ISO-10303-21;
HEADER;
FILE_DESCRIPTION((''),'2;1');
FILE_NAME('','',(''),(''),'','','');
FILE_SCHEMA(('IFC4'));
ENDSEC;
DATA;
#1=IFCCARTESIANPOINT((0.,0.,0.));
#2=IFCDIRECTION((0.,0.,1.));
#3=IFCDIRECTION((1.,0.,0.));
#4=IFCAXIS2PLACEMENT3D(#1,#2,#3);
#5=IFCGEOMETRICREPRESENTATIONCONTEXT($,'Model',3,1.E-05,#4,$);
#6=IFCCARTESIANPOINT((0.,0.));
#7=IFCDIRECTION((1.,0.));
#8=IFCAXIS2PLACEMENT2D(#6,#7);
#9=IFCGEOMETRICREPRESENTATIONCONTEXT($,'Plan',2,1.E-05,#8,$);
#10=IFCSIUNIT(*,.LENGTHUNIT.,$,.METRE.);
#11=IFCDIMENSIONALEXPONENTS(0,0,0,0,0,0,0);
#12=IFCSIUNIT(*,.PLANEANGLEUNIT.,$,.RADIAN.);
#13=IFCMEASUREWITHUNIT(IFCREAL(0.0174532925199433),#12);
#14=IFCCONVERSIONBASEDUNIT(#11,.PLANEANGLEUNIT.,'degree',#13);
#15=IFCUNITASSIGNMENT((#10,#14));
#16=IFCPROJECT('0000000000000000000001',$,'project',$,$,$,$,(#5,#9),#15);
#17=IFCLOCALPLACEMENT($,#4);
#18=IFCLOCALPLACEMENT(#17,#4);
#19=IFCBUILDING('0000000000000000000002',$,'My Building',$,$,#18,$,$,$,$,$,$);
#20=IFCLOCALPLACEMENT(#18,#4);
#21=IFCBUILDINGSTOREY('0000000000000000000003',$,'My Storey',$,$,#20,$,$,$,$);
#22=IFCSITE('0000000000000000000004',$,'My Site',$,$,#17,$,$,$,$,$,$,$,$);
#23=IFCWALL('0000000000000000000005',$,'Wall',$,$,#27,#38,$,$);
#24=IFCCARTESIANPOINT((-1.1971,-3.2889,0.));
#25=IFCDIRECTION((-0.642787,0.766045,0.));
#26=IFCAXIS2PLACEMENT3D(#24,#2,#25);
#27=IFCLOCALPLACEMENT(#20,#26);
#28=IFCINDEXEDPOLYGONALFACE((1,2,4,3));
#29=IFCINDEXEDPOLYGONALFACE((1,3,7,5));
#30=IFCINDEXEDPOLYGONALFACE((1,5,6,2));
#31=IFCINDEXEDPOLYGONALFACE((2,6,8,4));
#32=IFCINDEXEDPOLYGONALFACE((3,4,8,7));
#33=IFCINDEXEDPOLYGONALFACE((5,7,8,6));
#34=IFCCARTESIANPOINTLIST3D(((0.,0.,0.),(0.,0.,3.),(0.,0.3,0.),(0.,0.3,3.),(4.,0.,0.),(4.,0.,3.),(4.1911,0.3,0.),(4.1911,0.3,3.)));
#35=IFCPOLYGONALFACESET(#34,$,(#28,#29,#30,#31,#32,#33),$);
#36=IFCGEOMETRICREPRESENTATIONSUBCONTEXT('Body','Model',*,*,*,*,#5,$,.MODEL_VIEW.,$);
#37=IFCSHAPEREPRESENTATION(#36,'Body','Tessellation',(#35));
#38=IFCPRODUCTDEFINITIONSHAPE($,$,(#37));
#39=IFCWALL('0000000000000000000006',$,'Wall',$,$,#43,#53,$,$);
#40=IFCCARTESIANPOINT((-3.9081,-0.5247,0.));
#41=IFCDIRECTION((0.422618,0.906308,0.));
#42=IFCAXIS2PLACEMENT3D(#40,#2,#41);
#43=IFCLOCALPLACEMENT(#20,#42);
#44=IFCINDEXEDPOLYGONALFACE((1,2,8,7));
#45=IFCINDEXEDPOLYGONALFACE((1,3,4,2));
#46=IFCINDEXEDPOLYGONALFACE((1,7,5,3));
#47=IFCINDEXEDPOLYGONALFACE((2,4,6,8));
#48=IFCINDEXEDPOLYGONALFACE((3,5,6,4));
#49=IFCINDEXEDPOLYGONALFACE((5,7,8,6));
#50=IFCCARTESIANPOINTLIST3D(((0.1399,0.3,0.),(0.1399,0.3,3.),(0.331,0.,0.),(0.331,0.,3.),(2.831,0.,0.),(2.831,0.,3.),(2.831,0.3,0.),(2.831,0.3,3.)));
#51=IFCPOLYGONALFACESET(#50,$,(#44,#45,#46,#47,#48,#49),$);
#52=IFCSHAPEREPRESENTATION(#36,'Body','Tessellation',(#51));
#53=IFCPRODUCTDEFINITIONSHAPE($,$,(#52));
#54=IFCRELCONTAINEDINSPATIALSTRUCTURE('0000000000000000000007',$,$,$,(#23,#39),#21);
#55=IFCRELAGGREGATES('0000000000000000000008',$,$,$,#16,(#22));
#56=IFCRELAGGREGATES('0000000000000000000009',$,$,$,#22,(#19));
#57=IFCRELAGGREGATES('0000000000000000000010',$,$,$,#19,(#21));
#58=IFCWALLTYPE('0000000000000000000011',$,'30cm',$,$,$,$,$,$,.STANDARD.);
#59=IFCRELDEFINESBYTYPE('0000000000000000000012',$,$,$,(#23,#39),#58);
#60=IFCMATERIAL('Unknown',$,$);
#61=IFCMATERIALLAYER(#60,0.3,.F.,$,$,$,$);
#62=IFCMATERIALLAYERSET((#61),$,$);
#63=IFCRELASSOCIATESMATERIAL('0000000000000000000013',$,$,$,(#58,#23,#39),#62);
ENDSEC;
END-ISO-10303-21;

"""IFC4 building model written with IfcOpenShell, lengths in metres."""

from ifc_helpers import new_model, entity, si_unit, converted_unit, frame, origin_with_axes, origin_2d_with_axis, place, context, subcontext, project, spatial, indexed_curve, outline, extrude, clip, halfspace, material, layer, layer_set, layer_usage, type_object, element, save


model = new_model("IFC4")

# Units and contexts
model_context = context("Model", 3, precision=1e-05, world=origin_with_axes())
plan_context = context("Plan", 2, precision=1e-05, world=origin_2d_with_axis())
body_context = subcontext(model_context, "Body", "Model", "MODEL_VIEW")
ifc_project = project(units=[si_unit("LENGTHUNIT", "METRE"), converted_unit("PLANEANGLEUNIT", "degree", entity("IfcReal", 0.0174532925199433), si_unit("PLANEANGLEUNIT", "RADIAN"), dimensions=[0, 0, 0, 0, 0, 0, 0])], contexts=[model_context, plan_context])

# Site, building, storey
site_placement = place(None, origin_with_axes())
site = spatial("IfcSite", under=ifc_project, at=site_placement, Name="My Site")
building_placement = place(site_placement, origin_with_axes())
building = spatial("IfcBuilding", under=site, at=building_placement, Name="My Building")
storey_placement = place(building_placement, origin_with_axes())
storey = spatial("IfcBuildingStorey", under=building, at=storey_placement, Name="My Storey")

# Walls
ifc_material = material(Name="Unknown")
ifc_layer = layer(ifc_material, 0.3, ventilated=False)
ifc_layer_set = layer_set([ifc_layer])
ifc_layer_usage_1 = layer_usage(ifc_layer_set, "AXIS2", "POSITIVE", 0.0)
wall_type = type_object("IfcWallType", Name="30cm", PredefinedType="STANDARD", material=ifc_layer_set)
wall_1_placement = place(storey_placement, frame((-1.1971, -3.2889, 0.0), z_axis=(0.0, 0.0, 1.0), x_axis=(-0.642787, 0.766045, 0.0)))
element("IfcWall", 1, at=wall_1_placement, inside=storey, type_object=wall_type, material=ifc_layer_usage_1, Name="Wall", context=body_context, shape_type="Clipping", body=[
    clip(extrude(outline(indexed_curve([(0.0, 0.0), (0.0, 0.3), (4.331, 0.3), (4.331, 0.0), (0.0, 0.0)], self_intersect=False)), origin_with_axes(), (0.0, 0.0, 1.0), 3.0), halfspace(frame((4.0, 0.0, 0.0), z_axis=(0.843392, -0.537298, 0.0), x_axis=(-0.537298, -0.843392, 0.0)), False)),
])
ifc_layer_usage_2 = layer_usage(ifc_layer_set, "AXIS2", "POSITIVE", 0.0)
wall_2_placement = place(storey_placement, frame((-3.9081, -0.5247, 0.0), z_axis=(0.0, 0.0, 1.0), x_axis=(0.422618, 0.906308, 0.0)))
element("IfcWall", 2, at=wall_2_placement, inside=storey, type_object=wall_type, material=ifc_layer_usage_2, Name="Wall", context=body_context, shape_type="Clipping", body=[
    clip(extrude(outline(indexed_curve([(0.0, 0.0), (0.0, 0.3), (2.831, 0.3), (2.831, 0.0), (0.0, 0.0)], self_intersect=False)), origin_with_axes(), (0.0, 0.0, 1.0), 3.0), halfspace(frame((0.331, 0.0, 0.0), z_axis=(-0.843391, -0.5373, 0.0), x_axis=(-0.5373, 0.843391, 0.0)), False)),
])

save(model, "model.ifc")
